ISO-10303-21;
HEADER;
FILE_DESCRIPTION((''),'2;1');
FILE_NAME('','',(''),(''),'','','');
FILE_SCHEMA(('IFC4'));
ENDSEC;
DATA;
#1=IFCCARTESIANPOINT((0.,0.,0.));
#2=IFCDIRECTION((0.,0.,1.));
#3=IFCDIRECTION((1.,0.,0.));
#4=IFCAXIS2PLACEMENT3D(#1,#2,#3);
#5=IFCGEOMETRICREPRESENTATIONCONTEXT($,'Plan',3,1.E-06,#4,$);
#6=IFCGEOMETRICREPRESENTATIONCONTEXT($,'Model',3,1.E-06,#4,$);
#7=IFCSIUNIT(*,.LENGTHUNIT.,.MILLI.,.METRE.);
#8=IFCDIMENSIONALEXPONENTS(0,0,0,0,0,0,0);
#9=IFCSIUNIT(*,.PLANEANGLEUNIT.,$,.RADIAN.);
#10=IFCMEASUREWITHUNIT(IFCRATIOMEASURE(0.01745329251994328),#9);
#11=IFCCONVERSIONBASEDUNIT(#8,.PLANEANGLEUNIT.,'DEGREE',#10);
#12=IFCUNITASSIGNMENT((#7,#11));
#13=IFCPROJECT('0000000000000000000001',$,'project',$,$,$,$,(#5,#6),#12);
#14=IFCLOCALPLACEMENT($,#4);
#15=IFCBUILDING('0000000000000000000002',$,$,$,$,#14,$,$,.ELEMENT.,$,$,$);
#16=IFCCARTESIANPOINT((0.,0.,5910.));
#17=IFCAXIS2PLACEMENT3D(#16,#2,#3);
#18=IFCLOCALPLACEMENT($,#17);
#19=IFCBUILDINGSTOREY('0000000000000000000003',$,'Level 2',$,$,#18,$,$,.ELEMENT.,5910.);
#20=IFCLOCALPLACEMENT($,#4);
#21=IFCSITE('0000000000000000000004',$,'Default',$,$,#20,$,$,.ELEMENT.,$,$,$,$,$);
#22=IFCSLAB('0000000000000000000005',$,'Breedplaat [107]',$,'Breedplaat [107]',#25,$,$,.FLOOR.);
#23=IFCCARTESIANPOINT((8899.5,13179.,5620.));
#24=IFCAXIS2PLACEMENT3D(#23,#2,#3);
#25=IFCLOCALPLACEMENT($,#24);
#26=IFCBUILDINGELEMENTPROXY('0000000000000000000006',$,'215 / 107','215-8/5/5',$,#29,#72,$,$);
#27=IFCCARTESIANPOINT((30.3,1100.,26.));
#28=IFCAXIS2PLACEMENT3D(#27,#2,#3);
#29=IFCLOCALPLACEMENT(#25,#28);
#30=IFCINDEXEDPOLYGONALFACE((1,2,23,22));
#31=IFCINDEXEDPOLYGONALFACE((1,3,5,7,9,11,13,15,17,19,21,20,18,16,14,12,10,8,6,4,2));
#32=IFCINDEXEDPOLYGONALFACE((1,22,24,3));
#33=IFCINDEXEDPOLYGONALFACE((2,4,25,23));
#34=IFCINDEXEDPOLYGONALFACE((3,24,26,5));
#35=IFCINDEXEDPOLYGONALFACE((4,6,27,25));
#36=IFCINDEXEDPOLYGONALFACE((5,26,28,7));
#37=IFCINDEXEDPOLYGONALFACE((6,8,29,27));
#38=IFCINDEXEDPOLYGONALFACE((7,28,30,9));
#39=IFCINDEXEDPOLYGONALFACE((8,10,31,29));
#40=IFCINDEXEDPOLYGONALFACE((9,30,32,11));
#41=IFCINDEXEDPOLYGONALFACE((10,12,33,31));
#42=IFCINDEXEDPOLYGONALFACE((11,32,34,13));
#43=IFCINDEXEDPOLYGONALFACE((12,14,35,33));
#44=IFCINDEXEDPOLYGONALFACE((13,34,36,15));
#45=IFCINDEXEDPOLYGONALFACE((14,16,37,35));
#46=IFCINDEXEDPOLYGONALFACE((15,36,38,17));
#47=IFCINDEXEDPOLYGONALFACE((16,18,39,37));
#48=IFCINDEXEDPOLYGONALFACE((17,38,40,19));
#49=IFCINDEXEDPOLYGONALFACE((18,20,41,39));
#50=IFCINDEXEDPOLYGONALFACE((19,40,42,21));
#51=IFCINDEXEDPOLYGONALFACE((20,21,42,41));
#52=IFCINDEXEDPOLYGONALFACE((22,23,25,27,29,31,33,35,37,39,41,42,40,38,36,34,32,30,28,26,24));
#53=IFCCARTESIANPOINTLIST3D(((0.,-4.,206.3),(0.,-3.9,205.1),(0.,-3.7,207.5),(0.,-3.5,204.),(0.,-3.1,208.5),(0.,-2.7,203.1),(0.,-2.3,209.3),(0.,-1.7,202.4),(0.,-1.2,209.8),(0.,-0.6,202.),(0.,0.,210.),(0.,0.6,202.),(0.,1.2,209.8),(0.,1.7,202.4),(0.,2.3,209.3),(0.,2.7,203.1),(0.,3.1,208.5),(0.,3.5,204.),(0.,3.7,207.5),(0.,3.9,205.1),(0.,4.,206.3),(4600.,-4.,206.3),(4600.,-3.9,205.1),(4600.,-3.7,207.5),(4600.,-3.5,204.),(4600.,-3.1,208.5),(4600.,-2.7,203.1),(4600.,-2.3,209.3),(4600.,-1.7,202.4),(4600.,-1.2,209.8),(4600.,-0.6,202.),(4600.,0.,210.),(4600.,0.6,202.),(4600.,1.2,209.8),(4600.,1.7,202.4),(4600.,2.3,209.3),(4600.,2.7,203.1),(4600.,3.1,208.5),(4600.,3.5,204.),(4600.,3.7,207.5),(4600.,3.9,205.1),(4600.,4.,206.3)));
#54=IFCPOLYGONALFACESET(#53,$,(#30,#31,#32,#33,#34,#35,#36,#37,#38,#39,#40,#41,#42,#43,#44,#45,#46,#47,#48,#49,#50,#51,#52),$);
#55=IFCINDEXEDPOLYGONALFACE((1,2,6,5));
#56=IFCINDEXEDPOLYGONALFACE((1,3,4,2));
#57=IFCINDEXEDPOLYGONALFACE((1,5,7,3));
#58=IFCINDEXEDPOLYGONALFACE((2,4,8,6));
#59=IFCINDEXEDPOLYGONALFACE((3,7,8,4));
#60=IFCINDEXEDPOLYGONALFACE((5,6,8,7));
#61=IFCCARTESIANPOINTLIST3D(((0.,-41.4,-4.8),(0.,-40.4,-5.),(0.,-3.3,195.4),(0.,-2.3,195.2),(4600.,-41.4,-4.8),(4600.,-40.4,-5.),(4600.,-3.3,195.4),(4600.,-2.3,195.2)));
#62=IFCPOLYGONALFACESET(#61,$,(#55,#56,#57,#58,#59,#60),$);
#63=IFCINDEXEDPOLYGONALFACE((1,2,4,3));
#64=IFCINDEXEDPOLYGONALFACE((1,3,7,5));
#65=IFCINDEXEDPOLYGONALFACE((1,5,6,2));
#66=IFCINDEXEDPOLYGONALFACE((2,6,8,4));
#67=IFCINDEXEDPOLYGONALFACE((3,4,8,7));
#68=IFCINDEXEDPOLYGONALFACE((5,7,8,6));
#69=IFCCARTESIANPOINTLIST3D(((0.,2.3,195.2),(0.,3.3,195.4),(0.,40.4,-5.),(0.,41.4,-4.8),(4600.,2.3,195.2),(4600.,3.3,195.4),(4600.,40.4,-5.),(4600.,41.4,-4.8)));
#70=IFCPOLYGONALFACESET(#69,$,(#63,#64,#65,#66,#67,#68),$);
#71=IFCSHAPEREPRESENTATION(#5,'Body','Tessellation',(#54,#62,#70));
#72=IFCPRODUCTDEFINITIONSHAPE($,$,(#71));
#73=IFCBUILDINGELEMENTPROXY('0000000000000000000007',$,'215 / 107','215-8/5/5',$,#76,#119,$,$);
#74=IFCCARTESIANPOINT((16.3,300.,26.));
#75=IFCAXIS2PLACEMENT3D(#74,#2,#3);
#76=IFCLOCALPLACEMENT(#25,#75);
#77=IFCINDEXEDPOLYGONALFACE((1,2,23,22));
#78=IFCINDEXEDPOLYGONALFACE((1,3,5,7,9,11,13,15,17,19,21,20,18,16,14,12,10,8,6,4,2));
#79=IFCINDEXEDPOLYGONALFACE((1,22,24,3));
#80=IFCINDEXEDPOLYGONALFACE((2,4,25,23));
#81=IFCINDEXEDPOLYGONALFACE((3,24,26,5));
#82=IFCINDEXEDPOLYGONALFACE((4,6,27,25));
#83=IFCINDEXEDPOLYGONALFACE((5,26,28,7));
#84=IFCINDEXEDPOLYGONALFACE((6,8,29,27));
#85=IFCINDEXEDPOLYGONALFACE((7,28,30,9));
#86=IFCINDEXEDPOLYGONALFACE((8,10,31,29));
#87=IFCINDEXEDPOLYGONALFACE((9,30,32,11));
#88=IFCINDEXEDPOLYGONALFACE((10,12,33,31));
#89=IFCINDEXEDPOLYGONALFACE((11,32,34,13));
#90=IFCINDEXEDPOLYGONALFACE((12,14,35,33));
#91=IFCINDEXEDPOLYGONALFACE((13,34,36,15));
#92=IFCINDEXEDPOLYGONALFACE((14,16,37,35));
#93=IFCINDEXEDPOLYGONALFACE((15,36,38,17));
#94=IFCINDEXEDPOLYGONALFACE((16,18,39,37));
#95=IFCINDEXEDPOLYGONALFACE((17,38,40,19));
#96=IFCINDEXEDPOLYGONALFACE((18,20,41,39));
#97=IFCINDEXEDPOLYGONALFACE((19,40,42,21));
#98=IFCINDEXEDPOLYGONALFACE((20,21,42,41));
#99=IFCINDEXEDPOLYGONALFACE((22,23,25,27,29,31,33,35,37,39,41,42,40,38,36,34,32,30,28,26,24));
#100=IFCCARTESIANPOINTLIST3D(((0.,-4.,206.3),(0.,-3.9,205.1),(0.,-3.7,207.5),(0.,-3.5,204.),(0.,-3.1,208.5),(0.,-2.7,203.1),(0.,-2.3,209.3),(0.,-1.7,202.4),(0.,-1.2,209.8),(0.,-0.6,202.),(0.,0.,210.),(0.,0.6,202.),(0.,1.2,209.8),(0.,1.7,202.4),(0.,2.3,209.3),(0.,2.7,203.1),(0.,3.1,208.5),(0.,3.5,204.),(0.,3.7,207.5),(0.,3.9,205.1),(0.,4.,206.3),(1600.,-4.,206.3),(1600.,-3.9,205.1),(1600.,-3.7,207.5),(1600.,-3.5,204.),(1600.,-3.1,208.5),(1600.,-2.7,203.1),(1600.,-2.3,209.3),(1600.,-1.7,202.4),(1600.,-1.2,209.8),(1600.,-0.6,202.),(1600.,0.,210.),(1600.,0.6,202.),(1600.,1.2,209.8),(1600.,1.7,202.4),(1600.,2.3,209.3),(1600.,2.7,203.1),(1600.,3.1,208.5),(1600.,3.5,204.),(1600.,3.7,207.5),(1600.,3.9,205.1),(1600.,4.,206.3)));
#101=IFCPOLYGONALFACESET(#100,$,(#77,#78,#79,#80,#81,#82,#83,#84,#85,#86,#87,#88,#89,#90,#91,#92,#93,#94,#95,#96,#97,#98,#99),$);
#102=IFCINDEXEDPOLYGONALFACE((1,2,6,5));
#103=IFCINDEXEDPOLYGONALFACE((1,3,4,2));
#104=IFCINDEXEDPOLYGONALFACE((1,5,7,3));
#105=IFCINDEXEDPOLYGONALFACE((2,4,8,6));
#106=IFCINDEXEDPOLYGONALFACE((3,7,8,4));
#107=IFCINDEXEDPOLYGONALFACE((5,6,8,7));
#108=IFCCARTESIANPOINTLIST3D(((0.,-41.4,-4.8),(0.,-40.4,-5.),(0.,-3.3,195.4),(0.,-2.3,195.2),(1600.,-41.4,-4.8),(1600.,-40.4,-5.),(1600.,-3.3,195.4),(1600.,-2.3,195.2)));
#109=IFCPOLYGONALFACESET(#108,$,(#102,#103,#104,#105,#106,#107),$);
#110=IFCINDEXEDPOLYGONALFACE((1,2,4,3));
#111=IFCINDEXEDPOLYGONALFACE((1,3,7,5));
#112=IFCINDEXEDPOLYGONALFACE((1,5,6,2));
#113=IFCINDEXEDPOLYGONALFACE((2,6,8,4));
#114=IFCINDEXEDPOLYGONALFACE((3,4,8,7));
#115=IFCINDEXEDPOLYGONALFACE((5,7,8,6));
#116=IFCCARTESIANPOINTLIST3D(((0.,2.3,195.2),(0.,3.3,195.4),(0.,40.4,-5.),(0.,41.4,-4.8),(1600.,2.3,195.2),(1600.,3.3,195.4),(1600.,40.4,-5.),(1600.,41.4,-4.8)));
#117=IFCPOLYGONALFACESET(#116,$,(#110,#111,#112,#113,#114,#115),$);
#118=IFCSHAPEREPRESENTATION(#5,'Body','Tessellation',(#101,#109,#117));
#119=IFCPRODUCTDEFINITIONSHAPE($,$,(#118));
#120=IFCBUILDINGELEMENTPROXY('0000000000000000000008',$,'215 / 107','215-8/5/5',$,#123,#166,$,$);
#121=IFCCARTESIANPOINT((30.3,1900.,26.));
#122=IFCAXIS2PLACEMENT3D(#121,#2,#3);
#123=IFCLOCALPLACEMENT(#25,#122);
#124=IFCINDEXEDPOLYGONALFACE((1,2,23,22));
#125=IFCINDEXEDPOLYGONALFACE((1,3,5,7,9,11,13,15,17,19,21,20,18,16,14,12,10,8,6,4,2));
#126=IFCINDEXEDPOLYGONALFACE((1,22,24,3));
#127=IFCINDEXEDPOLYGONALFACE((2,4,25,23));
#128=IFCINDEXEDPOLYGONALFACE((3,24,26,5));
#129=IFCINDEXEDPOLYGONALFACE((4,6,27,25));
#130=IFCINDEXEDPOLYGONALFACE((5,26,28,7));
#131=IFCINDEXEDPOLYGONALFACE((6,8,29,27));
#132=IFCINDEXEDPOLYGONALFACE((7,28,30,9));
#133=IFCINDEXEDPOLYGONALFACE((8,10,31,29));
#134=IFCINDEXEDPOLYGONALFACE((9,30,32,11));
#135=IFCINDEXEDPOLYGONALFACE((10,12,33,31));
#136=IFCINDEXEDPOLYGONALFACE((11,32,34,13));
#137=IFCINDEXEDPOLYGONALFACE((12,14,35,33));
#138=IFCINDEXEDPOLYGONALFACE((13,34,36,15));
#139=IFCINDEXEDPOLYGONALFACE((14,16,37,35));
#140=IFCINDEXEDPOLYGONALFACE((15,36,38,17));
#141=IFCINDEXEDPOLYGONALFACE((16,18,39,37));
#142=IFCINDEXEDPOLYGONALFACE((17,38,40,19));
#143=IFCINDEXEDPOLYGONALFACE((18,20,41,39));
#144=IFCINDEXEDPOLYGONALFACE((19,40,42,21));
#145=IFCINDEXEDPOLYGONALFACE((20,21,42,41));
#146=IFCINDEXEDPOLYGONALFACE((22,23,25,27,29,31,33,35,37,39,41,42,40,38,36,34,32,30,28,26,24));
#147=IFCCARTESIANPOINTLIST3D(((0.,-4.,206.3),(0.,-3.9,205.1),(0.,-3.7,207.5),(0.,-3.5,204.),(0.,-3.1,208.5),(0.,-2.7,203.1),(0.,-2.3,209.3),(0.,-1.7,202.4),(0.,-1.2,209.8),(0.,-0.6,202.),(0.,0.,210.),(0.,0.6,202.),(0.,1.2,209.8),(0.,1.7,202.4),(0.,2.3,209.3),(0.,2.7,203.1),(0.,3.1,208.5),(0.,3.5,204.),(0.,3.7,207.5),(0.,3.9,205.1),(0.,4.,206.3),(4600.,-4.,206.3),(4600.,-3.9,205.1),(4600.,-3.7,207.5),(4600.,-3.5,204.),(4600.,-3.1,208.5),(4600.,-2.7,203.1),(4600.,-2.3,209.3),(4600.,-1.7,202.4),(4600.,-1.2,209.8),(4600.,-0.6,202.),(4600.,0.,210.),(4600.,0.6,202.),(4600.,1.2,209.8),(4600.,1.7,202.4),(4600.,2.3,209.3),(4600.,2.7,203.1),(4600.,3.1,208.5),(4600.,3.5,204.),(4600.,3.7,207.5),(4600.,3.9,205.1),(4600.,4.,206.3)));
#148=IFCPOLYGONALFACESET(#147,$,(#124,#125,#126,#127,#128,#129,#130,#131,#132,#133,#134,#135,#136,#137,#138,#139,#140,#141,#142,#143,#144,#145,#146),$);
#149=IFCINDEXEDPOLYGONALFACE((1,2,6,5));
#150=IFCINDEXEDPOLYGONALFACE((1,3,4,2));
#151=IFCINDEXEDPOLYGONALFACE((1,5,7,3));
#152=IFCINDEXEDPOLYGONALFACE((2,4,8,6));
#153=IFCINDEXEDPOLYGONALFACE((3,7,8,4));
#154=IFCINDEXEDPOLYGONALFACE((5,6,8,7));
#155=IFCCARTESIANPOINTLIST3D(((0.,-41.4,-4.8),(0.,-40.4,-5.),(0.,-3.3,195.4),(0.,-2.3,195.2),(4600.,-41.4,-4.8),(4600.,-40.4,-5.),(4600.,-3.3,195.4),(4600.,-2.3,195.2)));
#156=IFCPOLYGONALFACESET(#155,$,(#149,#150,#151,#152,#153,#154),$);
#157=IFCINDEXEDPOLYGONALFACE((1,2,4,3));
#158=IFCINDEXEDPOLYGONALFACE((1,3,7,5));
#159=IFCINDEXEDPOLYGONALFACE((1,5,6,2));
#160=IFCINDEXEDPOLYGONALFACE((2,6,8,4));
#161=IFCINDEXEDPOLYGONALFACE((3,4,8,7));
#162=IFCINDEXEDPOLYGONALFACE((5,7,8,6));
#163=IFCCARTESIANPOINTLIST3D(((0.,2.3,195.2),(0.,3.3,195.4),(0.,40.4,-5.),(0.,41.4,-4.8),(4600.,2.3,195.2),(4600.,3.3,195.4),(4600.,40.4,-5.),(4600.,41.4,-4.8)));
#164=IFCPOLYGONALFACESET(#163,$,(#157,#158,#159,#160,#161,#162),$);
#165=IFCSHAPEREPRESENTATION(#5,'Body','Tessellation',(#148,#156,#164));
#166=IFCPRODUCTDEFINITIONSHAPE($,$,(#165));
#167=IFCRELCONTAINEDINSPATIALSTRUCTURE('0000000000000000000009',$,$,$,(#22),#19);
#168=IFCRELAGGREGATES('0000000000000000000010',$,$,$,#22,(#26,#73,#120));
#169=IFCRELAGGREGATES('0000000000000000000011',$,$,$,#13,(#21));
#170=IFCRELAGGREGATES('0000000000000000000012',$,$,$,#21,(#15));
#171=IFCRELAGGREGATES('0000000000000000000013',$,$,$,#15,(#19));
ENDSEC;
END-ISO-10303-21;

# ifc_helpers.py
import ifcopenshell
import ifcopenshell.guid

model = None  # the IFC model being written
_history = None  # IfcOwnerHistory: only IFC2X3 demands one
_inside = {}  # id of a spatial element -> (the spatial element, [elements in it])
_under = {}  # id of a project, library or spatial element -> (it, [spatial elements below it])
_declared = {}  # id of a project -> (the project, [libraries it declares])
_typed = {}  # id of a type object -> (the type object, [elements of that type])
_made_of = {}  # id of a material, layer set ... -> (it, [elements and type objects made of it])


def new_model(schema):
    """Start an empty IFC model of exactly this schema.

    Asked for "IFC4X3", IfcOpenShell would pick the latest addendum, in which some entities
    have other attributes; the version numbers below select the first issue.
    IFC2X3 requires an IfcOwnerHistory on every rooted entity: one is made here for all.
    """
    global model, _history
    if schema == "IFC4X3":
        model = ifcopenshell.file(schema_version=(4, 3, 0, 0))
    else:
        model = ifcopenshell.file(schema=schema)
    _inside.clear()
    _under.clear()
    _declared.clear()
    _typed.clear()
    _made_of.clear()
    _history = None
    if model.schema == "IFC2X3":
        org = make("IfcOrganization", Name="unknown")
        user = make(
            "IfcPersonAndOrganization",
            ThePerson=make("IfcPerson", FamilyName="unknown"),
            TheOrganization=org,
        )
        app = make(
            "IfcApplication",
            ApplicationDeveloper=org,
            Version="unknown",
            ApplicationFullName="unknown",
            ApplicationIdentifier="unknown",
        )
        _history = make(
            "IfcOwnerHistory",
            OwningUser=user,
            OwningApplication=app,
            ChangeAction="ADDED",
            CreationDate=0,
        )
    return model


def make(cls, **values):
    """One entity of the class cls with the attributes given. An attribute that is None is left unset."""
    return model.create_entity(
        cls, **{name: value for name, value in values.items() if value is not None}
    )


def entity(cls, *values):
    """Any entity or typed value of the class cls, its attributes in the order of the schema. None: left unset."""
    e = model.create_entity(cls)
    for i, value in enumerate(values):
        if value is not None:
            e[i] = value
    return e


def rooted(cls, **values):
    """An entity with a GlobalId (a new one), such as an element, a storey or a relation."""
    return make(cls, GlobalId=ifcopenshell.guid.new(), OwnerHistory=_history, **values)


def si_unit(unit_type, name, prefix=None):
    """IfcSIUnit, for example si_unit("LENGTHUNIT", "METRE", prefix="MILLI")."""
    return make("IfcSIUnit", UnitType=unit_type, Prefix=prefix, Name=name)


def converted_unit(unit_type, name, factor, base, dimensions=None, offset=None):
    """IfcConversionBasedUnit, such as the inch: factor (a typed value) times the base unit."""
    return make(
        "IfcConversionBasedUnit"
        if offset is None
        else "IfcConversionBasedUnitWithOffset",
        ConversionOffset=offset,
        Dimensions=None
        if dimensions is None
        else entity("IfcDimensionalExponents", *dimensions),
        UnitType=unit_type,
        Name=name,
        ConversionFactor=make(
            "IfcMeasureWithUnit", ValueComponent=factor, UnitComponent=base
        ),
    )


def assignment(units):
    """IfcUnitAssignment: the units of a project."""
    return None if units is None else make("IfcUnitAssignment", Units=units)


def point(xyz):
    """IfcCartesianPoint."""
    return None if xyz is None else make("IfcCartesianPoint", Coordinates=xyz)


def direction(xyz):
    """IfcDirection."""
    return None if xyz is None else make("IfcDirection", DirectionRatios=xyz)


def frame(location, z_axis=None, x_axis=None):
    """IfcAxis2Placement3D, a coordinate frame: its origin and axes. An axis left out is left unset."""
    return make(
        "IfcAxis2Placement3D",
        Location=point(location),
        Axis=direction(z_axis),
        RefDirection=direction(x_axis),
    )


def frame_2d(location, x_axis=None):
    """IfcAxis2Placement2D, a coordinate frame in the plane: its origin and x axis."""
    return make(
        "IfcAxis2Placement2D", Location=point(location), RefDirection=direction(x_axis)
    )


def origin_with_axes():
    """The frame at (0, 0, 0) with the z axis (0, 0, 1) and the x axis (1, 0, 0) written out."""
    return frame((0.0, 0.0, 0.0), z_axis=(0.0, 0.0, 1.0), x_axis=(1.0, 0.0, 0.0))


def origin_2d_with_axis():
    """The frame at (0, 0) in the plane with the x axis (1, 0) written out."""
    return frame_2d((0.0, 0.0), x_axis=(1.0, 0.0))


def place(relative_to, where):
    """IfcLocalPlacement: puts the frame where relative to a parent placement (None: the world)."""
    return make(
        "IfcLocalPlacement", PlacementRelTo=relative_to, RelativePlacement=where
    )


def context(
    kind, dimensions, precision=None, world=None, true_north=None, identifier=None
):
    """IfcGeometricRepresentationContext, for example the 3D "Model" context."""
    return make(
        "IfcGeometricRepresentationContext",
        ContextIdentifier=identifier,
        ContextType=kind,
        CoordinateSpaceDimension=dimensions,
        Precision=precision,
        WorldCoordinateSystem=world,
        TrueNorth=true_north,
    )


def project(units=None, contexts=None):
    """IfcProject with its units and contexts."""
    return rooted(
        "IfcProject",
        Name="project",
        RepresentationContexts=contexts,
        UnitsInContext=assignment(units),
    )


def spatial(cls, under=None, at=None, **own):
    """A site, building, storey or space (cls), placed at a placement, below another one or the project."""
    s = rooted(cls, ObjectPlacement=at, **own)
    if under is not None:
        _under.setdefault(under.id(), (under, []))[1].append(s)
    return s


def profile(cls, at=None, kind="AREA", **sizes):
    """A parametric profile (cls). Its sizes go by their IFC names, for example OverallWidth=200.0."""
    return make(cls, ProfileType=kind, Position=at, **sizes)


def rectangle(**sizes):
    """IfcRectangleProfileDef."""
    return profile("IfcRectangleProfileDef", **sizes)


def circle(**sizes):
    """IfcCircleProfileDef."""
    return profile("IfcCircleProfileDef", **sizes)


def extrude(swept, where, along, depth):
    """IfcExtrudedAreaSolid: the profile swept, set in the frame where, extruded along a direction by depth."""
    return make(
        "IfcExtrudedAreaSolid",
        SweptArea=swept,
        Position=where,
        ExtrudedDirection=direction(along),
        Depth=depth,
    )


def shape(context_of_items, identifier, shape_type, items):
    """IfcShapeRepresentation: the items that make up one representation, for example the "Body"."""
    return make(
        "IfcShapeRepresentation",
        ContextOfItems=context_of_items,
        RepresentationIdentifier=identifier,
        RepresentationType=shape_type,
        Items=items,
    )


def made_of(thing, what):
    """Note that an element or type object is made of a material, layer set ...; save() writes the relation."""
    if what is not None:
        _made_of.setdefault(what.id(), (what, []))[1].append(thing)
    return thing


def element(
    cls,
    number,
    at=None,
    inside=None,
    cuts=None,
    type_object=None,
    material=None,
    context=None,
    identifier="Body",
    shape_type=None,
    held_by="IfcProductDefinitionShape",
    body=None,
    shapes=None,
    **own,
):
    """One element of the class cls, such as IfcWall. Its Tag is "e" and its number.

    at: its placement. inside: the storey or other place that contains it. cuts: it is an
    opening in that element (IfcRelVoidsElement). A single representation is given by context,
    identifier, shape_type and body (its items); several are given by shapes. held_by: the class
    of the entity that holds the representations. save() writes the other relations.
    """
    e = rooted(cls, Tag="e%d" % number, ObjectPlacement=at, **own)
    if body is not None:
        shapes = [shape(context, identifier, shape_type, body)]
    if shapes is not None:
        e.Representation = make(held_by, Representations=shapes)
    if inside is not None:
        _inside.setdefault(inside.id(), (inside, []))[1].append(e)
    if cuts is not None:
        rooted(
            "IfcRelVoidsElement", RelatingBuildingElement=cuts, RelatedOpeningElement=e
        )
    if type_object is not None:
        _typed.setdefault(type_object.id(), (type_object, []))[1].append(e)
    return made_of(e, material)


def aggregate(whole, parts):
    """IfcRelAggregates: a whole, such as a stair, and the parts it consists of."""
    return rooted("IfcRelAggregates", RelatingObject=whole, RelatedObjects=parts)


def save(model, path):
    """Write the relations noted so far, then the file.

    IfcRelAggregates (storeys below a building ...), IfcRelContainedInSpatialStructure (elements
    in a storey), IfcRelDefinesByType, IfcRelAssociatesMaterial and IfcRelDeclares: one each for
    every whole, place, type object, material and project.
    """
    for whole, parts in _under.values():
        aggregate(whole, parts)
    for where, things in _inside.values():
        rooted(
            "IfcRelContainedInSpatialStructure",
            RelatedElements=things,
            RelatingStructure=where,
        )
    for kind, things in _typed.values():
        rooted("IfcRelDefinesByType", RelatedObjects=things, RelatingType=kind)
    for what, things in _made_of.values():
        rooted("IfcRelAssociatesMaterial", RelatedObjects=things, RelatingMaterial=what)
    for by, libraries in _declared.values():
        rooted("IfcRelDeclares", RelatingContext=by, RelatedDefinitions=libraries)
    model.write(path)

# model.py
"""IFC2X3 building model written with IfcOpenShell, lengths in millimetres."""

from ifc_helpers import new_model, entity, si_unit, converted_unit, frame, origin_with_axes, origin_2d_with_axis, place, context, project, spatial, rectangle, circle, extrude, element, aggregate, save


model = new_model("IFC2X3")

# Units and contexts
plan_context = context("Plan", 3, precision=1e-06, world=origin_with_axes())
model_context = context("Model", 3, precision=1e-06, world=origin_with_axes())
ifc_project = project(units=[si_unit("LENGTHUNIT", "METRE", prefix="MILLI"), converted_unit("PLANEANGLEUNIT", "DEGREE", entity("IfcRatioMeasure", 0.01745329251994328), si_unit("PLANEANGLEUNIT", "RADIAN"), dimensions=[0, 0, 0, 0, 0, 0, 0])], contexts=[plan_context, model_context])

# Site, building, storey
site_placement = place(None, origin_with_axes())
site = spatial("IfcSite", under=ifc_project, at=site_placement, Name="Default", CompositionType="ELEMENT")
building_placement = place(None, origin_with_axes())
building = spatial("IfcBuilding", under=site, at=building_placement, CompositionType="ELEMENT")
storey_placement = place(None, frame((0.0, 0.0, 5910.0), z_axis=(0.0, 0.0, 1.0), x_axis=(1.0, 0.0, 0.0)))
storey = spatial("IfcBuildingStorey", under=building, at=storey_placement, Name="Level 2", CompositionType="ELEMENT", Elevation=5910.0)

# Slab, building element proxies
slab_1_placement = place(None, frame((8899.5, 13179.0, 5620.0), z_axis=(0.0, 0.0, 1.0), x_axis=(1.0, 0.0, 0.0)))
slab_1 = element("IfcSlab", 1, at=slab_1_placement, inside=storey, Name="Breedplaat [107]", ObjectType="Breedplaat [107]", PredefinedType="FLOOR")
proxy_1_placement = place(slab_1_placement, frame((30.3, 1100.0, 26.0), z_axis=(0.0, 0.0, 1.0), x_axis=(1.0, 0.0, 0.0)))
proxy_1 = element("IfcBuildingElementProxy", 2, at=proxy_1_placement, Name="215 / 107", Description="215-8/5/5", context=plan_context, shape_type="SweptSolid", body=[
    extrude(circle(Radius=4.0, at=origin_2d_with_axis()), frame((0.0, 0.0, 206.0), z_axis=(1.0, 0.0, 0.0), x_axis=(0.0, 0.0, 1.0)), (0.0, 0.0, 1.0), 4600.0),
    extrude(rectangle(XDim=203.8, YDim=1.0, at=origin_2d_with_axis()), frame((0.0, -21.9, 95.2), z_axis=(1.0, 0.0, 0.0), x_axis=(0.0, 0.187112, 0.982339)), (0.0, 0.0, 1.0), 4600.0),
    extrude(rectangle(XDim=203.8, YDim=1.0, at=origin_2d_with_axis()), frame((0.0, 21.9, 95.2), z_axis=(1.0, 0.0, 0.0), x_axis=(0.0, -0.187112, 0.982339)), (0.0, 0.0, 1.0), 4600.0),
])
proxy_2_placement = place(slab_1_placement, frame((16.3, 300.0, 26.0), z_axis=(0.0, 0.0, 1.0), x_axis=(1.0, 0.0, 0.0)))
proxy_2 = element("IfcBuildingElementProxy", 3, at=proxy_2_placement, Name="215 / 107", Description="215-8/5/5", context=plan_context, shape_type="SweptSolid", body=[
    extrude(circle(Radius=4.0, at=origin_2d_with_axis()), frame((0.0, 0.0, 206.0), z_axis=(1.0, 0.0, 0.0), x_axis=(0.0, 0.0, 1.0)), (0.0, 0.0, 1.0), 1600.0),
    extrude(rectangle(XDim=203.8, YDim=1.0, at=origin_2d_with_axis()), frame((0.0, -21.9, 95.2), z_axis=(1.0, 0.0, 0.0), x_axis=(0.0, 0.187112, 0.982339)), (0.0, 0.0, 1.0), 1600.0),
    extrude(rectangle(XDim=203.8, YDim=1.0, at=origin_2d_with_axis()), frame((0.0, 21.9, 95.2), z_axis=(1.0, 0.0, 0.0), x_axis=(0.0, -0.187112, 0.982339)), (0.0, 0.0, 1.0), 1600.0),
])
proxy_3_placement = place(slab_1_placement, frame((30.3, 1900.0, 26.0), z_axis=(0.0, 0.0, 1.0), x_axis=(1.0, 0.0, 0.0)))
proxy_3 = element("IfcBuildingElementProxy", 4, at=proxy_3_placement, Name="215 / 107", Description="215-8/5/5", context=plan_context, shape_type="SweptSolid", body=[
    extrude(circle(Radius=4.0, at=origin_2d_with_axis()), frame((0.0, 0.0, 206.0), z_axis=(1.0, 0.0, 0.0), x_axis=(0.0, 0.0, 1.0)), (0.0, 0.0, 1.0), 4600.0),
    extrude(rectangle(XDim=203.8, YDim=1.0, at=origin_2d_with_axis()), frame((0.0, -21.9, 95.2), z_axis=(1.0, 0.0, 0.0), x_axis=(0.0, 0.187112, 0.982339)), (0.0, 0.0, 1.0), 4600.0),
    extrude(rectangle(XDim=203.8, YDim=1.0, at=origin_2d_with_axis()), frame((0.0, 21.9, 95.2), z_axis=(1.0, 0.0, 0.0), x_axis=(0.0, -0.187112, 0.982339)), (0.0, 0.0, 1.0), 4600.0),
])
aggregate(slab_1, [proxy_1, proxy_2, proxy_3])

save(model, "model.ifc")
